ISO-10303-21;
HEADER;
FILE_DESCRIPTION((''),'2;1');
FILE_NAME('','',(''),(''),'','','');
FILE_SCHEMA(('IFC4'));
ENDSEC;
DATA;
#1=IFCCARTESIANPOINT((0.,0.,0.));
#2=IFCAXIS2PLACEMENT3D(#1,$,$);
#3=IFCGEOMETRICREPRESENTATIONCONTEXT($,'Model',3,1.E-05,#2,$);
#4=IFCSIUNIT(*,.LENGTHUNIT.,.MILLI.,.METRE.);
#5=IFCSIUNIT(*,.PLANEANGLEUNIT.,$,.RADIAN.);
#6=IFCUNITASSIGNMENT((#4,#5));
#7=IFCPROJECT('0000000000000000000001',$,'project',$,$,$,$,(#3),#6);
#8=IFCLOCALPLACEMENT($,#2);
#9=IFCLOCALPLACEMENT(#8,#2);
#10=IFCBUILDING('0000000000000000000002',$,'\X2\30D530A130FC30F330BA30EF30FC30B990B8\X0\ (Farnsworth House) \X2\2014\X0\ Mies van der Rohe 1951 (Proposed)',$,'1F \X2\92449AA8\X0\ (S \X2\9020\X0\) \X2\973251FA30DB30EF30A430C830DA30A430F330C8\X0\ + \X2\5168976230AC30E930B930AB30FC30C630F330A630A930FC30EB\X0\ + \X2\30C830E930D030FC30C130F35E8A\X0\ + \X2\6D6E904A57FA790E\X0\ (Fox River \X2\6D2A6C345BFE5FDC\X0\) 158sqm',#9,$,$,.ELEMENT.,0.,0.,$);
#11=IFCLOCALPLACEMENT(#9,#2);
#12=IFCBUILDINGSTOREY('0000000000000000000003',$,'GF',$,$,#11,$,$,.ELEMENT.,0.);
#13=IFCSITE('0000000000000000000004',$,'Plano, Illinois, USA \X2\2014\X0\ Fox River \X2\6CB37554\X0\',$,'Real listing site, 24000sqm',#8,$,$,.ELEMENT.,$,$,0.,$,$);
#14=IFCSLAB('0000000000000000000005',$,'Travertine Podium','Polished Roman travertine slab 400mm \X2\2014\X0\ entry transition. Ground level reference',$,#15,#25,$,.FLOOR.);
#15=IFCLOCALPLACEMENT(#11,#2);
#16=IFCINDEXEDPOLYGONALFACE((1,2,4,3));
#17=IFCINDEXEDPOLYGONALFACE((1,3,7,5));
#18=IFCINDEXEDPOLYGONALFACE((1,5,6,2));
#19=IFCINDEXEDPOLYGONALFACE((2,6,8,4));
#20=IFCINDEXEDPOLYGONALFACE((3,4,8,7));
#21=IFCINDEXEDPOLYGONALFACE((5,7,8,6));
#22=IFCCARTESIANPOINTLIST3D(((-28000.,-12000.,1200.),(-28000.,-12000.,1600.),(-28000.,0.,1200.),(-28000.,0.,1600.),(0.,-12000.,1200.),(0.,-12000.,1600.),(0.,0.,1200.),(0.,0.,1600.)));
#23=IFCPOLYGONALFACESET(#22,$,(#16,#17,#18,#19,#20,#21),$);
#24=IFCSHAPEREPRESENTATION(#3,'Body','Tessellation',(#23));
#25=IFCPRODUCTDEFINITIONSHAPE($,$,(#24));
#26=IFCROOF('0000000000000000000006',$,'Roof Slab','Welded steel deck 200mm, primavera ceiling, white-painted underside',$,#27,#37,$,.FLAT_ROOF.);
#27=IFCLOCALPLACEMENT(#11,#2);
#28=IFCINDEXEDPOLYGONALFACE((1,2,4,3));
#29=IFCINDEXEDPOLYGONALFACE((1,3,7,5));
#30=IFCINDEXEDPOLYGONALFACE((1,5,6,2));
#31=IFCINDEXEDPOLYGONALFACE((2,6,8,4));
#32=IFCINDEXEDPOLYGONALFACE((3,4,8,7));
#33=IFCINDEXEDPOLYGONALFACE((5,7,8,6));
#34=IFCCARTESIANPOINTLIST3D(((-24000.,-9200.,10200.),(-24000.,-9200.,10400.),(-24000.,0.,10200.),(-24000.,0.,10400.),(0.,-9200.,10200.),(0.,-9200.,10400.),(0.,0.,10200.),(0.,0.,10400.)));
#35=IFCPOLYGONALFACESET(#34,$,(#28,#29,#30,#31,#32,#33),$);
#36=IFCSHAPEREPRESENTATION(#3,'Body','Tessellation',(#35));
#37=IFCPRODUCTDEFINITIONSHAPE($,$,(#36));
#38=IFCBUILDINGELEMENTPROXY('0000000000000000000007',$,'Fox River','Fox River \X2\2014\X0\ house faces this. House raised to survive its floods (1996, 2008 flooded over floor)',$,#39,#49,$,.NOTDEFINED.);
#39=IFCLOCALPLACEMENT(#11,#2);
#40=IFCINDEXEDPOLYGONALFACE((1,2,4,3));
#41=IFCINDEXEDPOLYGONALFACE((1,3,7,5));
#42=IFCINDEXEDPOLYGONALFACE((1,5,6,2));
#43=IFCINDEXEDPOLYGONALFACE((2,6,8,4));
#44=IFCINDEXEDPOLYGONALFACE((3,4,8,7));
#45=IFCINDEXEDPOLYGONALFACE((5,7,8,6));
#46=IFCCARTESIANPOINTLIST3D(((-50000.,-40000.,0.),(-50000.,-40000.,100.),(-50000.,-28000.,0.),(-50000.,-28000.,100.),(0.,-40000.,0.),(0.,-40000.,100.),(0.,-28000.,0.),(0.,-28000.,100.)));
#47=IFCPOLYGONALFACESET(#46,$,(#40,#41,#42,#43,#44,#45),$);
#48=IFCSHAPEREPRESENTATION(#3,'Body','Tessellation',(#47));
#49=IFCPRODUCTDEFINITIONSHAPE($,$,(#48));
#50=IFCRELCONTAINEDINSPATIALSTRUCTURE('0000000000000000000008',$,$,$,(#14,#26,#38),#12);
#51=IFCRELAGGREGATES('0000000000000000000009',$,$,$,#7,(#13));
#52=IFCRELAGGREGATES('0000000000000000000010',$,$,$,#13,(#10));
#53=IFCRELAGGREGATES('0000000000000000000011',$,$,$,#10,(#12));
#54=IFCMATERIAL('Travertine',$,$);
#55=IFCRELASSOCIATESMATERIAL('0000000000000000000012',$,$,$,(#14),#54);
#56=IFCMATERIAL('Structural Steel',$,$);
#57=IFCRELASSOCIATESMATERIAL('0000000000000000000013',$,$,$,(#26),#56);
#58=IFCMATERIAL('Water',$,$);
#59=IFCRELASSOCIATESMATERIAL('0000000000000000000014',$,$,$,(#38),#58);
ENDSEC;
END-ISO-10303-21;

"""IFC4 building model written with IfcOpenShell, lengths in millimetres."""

from ifc_helpers import new_model, si_unit, frame, frame_2d, origin, place, context, project, spatial, rectangle, extrude, material, element, save


model = new_model("IFC4")

# Units and contexts
model_context = context("Model", 3, precision=1e-05, world=origin())
ifc_project = project(units=[si_unit("LENGTHUNIT", "METRE", prefix="MILLI"), si_unit("PLANEANGLEUNIT", "RADIAN")], contexts=[model_context])

# Site, building, storey
site_placement = place(None, origin())
site = spatial("IfcSite", under=ifc_project, at=site_placement, Name="Plano, Illinois, USA — Fox River 河畔", ObjectType="Real listing site, 24000sqm", CompositionType="ELEMENT", RefElevation=0.0)
building_placement = place(site_placement, origin())
building = spatial("IfcBuilding", under=site, at=building_placement, Name="ファーンズワース邸 (Farnsworth House) — Mies van der Rohe 1951 (Proposed)", ObjectType="1F 鉄骨 (S 造) 露出ホワイトペイント + 全面ガラスカーテンウォール + トラバーチン床 + 浮遊基礎 (Fox River 洪水対応) 158sqm", CompositionType="ELEMENT", ElevationOfRefHeight=0.0, ElevationOfTerrain=0.0)
storey_placement = place(building_placement, origin())
storey = spatial("IfcBuildingStorey", under=building, at=storey_placement, Name="GF", CompositionType="ELEMENT", Elevation=0.0)

# Shared definitions
ifc_material_1 = material(Name="Structural Steel")

# Slab
ifc_material_2 = material(Name="Travertine")
slab_1_placement = place(storey_placement, frame((-14000.0, -6000.0, 600.0)))
element("IfcSlab", 1, at=slab_1_placement, inside=storey, material=ifc_material_2, Name="Travertine Podium", Description="Polished Roman travertine slab 400mm — entry transition. Ground level reference", PredefinedType="FLOOR", context=model_context, shape_type="SweptSolid", body=[
    extrude(rectangle(XDim=28000.0, YDim=12000.0, at=frame_2d((14000.0, 6000.0))), frame((-14000.0, -6000.0, 600.0)), (0.0, 0.0, 1.0), 400.0),
])

# Roof
roof_placement = place(storey_placement, frame((-12000.0, -4600.0, 5100.0)))
element("IfcRoof", 2, at=roof_placement, inside=storey, material=ifc_material_1, Name="Roof Slab", Description="Welded steel deck 200mm, primavera ceiling, white-painted underside", PredefinedType="FLAT_ROOF", context=model_context, shape_type="SweptSolid", body=[
    extrude(rectangle(XDim=24000.0, YDim=9200.0, at=frame_2d((12000.0, 4600.0))), frame((-12000.0, -4600.0, 5100.0)), (0.0, 0.0, 1.0), 200.0),
])

# Building element proxy
ifc_material_3 = material(Name="Water")
proxy_1_placement = place(storey_placement, frame((-25000.0, -20000.0, 0.0)))
element("IfcBuildingElementProxy", 3, at=proxy_1_placement, inside=storey, material=ifc_material_3, Name="Fox River", Description="Fox River — house faces this. House raised to survive its floods (1996, 2008 flooded over floor)", PredefinedType="NOTDEFINED", context=model_context, shape_type="SweptSolid", body=[
    extrude(rectangle(XDim=50000.0, YDim=12000.0, at=frame_2d((25000.0, 6000.0))), frame((-25000.0, -20000.0, 0.0)), (0.0, 0.0, 1.0), 100.0),
])

save(model, "model.ifc")
